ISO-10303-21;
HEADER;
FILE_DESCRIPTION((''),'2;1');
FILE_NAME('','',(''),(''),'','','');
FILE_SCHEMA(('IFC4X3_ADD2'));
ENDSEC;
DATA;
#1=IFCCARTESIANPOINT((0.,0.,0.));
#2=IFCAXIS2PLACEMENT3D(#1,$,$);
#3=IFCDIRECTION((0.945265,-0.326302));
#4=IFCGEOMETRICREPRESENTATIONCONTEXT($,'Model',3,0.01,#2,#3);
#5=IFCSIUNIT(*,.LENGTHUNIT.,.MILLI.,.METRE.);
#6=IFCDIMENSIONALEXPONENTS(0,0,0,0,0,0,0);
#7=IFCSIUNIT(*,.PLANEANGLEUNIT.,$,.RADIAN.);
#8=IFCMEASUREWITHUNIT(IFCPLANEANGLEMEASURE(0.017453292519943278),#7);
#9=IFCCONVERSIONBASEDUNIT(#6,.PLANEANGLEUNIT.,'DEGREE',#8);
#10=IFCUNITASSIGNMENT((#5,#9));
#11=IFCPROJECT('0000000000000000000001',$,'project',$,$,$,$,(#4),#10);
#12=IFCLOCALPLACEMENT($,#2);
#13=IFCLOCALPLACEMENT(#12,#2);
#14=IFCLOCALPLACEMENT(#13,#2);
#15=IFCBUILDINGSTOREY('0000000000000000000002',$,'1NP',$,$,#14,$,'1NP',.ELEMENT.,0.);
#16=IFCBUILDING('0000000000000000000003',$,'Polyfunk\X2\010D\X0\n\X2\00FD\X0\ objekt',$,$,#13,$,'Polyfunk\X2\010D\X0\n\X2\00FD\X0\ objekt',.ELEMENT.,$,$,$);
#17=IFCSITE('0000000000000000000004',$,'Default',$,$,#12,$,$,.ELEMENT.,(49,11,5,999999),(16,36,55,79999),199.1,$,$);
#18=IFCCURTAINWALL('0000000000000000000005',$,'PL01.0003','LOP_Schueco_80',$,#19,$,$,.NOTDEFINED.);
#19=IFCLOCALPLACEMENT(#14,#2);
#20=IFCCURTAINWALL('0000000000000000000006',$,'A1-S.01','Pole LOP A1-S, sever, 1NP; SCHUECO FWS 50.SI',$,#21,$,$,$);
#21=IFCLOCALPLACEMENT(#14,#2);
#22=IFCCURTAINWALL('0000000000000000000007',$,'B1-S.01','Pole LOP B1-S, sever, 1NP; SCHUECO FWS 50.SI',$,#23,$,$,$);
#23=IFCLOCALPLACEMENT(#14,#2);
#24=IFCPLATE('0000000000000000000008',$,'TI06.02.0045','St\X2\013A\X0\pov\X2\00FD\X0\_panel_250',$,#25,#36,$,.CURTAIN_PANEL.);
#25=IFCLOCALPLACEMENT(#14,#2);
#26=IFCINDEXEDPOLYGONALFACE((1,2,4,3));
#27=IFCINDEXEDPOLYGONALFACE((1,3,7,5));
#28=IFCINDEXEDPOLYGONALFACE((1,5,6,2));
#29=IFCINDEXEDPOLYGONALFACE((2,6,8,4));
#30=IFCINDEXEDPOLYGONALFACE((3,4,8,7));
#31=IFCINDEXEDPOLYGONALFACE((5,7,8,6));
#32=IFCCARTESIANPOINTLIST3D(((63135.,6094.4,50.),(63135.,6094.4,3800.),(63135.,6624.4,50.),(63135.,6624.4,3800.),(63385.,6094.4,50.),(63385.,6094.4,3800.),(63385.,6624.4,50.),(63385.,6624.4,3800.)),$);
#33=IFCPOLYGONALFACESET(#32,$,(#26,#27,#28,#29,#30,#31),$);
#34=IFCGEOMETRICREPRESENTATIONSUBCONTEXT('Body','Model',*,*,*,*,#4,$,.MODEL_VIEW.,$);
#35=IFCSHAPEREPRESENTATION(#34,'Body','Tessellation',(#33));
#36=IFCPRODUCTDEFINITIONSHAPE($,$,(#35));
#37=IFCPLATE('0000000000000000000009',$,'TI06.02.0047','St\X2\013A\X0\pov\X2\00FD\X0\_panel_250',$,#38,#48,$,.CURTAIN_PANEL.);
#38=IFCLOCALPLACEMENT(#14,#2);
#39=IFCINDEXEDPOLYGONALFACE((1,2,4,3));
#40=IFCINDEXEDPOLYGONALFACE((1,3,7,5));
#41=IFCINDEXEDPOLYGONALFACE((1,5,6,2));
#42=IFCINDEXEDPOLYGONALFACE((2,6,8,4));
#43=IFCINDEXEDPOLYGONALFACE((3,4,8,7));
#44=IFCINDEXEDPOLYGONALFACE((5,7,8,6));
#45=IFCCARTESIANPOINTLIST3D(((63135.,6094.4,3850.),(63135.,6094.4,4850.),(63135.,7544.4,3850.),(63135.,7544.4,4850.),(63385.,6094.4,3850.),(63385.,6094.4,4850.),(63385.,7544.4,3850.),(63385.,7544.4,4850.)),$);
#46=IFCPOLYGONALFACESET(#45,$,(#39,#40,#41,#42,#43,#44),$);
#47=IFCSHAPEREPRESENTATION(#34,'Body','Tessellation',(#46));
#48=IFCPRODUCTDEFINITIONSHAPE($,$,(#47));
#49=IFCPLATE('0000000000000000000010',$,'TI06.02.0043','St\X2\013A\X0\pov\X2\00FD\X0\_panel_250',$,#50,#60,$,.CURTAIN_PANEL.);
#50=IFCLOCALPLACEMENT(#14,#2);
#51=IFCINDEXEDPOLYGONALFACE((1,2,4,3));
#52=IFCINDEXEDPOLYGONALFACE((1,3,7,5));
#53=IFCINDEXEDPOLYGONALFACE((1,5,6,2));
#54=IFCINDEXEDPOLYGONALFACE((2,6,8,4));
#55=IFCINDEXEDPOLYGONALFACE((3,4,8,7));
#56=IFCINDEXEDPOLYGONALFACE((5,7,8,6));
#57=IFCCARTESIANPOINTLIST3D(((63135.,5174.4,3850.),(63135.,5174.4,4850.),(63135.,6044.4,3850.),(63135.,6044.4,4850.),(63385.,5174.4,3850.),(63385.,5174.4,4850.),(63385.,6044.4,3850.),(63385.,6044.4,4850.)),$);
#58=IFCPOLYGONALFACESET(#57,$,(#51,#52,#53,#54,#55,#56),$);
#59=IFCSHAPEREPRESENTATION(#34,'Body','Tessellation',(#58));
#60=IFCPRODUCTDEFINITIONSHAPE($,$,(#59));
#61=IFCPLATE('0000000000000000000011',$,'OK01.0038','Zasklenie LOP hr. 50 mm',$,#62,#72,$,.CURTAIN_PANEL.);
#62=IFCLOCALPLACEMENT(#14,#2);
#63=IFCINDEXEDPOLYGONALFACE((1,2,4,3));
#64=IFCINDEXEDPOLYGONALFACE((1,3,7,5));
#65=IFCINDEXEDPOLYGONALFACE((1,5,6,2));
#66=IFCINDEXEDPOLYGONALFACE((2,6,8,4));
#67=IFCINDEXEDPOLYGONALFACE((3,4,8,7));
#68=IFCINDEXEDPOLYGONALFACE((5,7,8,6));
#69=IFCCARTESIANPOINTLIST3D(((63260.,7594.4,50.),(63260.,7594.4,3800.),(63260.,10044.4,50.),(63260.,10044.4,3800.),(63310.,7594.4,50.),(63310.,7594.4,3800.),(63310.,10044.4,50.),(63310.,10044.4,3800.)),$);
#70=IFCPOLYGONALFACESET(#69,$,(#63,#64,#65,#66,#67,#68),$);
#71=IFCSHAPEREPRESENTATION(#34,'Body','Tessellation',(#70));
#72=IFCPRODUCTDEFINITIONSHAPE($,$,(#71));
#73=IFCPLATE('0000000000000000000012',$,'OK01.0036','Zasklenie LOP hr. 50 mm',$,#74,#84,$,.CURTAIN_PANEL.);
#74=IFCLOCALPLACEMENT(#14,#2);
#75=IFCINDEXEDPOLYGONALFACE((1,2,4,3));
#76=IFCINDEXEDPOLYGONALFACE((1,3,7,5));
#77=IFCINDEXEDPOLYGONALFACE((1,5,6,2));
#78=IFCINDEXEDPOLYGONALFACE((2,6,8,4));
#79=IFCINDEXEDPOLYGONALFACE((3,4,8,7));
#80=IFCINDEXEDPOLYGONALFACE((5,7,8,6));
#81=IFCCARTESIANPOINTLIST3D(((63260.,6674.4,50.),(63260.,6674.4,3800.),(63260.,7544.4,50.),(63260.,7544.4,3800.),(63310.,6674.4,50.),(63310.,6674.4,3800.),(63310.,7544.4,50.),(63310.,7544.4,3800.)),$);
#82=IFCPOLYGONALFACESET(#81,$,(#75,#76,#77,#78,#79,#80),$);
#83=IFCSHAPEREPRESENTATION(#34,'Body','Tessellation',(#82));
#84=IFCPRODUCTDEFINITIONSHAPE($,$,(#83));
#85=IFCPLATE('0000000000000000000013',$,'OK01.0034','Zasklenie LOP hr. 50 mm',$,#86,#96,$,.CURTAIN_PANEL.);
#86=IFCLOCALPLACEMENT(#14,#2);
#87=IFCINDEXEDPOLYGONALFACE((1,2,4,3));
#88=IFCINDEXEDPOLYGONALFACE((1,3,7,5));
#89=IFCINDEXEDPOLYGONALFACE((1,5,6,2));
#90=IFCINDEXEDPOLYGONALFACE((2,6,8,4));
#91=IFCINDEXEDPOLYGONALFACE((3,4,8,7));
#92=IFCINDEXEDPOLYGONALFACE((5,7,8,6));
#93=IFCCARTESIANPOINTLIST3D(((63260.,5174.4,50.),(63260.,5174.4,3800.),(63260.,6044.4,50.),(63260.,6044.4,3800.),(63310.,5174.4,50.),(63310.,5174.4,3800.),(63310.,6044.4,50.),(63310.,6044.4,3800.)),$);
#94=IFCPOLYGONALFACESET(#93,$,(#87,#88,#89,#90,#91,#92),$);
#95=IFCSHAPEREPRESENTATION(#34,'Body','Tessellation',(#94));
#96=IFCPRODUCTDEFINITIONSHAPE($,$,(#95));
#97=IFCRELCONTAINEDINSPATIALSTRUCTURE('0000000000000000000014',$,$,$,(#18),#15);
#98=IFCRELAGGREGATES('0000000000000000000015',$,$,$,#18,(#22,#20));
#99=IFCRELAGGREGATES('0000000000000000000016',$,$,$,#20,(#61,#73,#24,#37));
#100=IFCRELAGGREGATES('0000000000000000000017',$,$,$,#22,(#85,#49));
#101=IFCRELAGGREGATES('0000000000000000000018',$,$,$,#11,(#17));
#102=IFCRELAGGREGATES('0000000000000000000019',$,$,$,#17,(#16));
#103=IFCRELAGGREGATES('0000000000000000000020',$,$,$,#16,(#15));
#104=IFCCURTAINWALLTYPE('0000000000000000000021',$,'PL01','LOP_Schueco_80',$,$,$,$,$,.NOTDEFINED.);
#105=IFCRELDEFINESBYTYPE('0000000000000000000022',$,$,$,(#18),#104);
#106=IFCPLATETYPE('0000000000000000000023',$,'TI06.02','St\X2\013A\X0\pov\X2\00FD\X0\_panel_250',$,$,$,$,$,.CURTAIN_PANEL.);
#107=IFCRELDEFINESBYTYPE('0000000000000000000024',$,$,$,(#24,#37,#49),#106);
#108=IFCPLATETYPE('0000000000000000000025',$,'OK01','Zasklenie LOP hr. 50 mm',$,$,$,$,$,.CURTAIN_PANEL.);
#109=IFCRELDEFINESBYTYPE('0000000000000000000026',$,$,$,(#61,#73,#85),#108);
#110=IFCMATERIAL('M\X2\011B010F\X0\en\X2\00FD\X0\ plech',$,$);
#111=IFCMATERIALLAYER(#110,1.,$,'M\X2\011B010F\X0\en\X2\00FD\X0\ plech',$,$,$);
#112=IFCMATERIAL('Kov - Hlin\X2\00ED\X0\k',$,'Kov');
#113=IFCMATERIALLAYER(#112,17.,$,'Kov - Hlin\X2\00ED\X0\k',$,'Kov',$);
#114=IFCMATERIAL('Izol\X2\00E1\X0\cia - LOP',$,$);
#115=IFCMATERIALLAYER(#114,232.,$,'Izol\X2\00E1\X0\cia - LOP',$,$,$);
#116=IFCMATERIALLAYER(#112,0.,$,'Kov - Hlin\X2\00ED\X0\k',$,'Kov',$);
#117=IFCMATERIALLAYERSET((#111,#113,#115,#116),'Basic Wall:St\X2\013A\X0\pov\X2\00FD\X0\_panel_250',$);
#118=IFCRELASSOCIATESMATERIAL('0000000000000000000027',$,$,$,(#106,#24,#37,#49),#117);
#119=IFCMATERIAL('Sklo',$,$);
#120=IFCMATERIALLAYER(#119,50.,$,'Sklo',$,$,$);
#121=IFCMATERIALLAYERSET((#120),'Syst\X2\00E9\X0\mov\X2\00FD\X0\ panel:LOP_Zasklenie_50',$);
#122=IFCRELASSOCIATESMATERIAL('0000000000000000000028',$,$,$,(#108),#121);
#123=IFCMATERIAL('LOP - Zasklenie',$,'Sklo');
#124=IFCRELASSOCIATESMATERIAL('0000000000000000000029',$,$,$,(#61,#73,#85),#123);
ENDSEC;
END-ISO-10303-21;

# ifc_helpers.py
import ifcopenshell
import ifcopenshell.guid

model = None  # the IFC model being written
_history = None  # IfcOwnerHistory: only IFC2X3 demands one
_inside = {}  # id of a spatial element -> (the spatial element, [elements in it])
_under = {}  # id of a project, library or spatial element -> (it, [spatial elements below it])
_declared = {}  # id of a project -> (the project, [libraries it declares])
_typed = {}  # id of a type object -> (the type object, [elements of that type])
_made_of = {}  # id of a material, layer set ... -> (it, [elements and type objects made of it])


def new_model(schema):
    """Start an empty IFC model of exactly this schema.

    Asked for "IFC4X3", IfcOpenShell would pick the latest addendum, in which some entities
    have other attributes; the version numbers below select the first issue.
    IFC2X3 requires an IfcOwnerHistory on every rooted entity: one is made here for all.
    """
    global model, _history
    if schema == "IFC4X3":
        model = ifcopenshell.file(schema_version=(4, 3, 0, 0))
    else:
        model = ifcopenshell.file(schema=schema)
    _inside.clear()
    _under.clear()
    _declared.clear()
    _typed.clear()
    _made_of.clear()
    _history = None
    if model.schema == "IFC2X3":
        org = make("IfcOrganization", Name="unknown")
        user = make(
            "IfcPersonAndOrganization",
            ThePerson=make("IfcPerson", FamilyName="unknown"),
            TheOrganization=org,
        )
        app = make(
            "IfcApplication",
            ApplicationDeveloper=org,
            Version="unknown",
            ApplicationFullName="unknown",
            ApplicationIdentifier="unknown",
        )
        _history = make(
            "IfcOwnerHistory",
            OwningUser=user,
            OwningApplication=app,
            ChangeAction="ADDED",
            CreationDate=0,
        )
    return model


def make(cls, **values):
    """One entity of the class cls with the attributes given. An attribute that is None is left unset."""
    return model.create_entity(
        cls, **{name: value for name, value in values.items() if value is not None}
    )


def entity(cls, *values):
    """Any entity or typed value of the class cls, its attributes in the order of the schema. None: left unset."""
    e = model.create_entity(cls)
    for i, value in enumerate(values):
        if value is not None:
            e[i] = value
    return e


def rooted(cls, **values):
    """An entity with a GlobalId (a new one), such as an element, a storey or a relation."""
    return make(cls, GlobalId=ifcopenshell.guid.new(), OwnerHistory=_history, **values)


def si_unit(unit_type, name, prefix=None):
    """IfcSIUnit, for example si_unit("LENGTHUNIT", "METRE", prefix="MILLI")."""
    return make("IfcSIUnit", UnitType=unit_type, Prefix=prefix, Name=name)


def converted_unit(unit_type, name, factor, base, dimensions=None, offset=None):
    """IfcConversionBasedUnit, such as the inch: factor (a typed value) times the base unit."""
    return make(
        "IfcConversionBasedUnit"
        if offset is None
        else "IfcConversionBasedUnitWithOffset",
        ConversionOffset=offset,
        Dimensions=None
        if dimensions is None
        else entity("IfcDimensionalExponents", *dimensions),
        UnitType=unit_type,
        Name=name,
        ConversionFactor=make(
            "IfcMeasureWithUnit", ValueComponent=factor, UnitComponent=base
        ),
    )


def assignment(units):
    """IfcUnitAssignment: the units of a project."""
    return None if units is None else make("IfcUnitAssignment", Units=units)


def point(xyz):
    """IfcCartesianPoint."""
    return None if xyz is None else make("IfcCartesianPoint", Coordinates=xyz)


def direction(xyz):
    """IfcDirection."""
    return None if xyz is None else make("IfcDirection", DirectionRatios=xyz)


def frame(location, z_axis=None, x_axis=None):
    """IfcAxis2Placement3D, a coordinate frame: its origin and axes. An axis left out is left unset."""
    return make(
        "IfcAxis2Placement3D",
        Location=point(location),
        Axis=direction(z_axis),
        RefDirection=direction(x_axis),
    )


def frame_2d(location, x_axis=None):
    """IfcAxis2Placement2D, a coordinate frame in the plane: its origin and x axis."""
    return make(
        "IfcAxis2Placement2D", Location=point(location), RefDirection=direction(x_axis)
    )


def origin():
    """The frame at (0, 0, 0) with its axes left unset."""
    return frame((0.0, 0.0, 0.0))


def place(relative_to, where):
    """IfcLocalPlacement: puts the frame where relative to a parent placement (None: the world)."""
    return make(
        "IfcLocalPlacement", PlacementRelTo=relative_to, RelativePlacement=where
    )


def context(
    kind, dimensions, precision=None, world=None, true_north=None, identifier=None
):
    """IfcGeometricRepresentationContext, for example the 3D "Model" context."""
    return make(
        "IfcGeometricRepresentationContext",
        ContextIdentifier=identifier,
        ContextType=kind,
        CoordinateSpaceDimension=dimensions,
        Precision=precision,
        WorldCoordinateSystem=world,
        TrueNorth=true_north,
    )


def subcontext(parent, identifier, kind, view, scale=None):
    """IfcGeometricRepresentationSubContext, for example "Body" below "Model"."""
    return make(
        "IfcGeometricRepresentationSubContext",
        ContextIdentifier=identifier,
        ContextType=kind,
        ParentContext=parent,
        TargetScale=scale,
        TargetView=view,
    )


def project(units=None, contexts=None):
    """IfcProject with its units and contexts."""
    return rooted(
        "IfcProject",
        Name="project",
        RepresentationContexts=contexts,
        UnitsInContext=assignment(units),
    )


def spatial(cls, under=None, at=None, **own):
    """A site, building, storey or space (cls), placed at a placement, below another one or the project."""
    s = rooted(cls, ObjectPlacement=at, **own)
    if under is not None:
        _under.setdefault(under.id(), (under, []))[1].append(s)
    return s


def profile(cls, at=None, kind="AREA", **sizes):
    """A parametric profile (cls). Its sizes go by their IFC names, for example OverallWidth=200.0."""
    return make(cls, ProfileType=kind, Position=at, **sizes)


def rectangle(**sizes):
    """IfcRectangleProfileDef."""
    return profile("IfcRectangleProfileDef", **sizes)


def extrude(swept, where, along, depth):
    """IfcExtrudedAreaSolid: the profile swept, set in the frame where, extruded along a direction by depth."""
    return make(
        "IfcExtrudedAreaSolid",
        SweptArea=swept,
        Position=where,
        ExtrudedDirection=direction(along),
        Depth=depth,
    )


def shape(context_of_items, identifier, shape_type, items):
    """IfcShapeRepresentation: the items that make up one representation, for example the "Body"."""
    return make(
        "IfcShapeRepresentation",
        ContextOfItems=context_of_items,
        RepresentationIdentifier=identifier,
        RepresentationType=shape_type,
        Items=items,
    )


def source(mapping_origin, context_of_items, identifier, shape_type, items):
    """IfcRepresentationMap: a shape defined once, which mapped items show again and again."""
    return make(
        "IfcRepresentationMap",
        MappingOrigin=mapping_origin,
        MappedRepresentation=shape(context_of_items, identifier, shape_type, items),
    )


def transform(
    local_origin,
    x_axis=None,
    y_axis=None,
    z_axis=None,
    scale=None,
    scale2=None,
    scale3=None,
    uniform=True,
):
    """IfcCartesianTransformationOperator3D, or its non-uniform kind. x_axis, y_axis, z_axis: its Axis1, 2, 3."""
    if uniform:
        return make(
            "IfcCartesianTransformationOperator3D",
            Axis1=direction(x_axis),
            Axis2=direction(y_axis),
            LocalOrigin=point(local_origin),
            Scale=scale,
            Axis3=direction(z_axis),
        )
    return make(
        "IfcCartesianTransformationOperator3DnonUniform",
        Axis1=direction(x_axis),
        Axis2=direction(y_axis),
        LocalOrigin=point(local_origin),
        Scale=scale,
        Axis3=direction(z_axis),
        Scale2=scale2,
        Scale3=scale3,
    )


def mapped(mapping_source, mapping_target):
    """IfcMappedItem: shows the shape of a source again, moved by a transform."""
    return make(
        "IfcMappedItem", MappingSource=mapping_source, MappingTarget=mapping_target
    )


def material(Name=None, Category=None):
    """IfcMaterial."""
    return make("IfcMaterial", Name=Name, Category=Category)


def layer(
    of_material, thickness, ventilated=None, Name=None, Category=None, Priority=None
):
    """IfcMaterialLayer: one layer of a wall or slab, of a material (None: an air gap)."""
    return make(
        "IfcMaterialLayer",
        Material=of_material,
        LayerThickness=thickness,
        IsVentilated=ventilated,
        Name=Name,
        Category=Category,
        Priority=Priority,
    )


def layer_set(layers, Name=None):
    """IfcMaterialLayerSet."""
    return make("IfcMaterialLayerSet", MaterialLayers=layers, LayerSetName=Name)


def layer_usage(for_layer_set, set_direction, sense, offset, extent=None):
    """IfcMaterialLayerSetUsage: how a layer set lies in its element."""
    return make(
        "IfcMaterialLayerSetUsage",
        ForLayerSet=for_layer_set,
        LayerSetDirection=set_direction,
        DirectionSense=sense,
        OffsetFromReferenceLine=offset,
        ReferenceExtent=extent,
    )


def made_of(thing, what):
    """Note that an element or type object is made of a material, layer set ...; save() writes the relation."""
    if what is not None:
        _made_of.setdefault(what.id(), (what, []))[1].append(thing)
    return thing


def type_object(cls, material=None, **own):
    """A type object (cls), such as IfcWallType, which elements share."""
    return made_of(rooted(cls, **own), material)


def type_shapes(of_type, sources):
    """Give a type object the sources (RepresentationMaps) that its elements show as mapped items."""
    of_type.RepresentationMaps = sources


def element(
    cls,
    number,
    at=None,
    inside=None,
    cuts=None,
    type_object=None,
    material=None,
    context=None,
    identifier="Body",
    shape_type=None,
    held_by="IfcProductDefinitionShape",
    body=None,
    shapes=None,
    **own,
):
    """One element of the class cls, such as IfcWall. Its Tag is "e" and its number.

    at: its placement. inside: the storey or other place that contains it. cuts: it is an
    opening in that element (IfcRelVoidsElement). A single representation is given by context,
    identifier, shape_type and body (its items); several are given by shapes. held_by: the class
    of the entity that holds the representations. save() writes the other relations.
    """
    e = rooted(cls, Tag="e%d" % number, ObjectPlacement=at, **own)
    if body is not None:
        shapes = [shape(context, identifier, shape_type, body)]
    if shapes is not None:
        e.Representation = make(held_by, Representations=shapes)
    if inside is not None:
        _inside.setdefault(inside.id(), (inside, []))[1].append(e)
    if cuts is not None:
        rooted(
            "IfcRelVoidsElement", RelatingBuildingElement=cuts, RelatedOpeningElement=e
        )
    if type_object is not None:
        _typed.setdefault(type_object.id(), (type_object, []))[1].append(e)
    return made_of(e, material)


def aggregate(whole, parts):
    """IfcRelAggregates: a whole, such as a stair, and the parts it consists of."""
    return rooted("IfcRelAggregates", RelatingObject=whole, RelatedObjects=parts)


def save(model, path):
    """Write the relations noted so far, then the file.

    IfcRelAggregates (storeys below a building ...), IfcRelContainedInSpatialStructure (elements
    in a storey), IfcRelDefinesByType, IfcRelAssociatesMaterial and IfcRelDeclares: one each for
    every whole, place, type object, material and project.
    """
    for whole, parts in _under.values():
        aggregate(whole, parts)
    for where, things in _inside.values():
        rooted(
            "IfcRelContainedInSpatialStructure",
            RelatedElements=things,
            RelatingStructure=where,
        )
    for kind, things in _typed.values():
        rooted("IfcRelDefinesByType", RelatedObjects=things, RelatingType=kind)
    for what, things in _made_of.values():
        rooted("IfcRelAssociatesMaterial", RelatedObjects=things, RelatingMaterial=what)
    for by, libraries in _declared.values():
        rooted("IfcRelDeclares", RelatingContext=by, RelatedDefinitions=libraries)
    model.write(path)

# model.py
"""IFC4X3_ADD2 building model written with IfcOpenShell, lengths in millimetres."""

from ifc_helpers import new_model, entity, si_unit, converted_unit, direction, frame, frame_2d, origin, place, context, subcontext, project, spatial, rectangle, extrude, source, transform, mapped, material, layer, layer_set, layer_usage, type_object, type_shapes, element, aggregate, save


model = new_model("IFC4X3_ADD2")

# Units and contexts
model_context = context("Model", 3, precision=0.01, world=origin(), true_north=direction((0.945265, -0.326302)))
body_context = subcontext(model_context, "Body", "Model", "MODEL_VIEW")
ifc_project = project(units=[si_unit("LENGTHUNIT", "METRE", prefix="MILLI"), converted_unit("PLANEANGLEUNIT", "DEGREE", entity("IfcPlaneAngleMeasure", 0.017453292519943278), si_unit("PLANEANGLEUNIT", "RADIAN"), dimensions=[0, 0, 0, 0, 0, 0, 0])], contexts=[model_context])

# Site, building, storey
site_placement = place(None, origin())
site = spatial("IfcSite", under=ifc_project, at=site_placement, Name="Default", CompositionType="ELEMENT", RefLatitude=(49, 11, 5, 999999), RefLongitude=(16, 36, 55, 79999), RefElevation=199.1)
building_placement = place(site_placement, origin())
building = spatial("IfcBuilding", under=site, at=building_placement, Name="Polyfunkčný objekt", LongName="Polyfunkčný objekt", CompositionType="ELEMENT")
storey_placement = place(building_placement, origin())
storey = spatial("IfcBuildingStorey", under=building, at=storey_placement, Name="1NP", LongName="1NP", CompositionType="ELEMENT", Elevation=0.0)

# Curtain walls, plates
curtain_wall_type = type_object("IfcCurtainWallType", Name="PL01", Description="LOP_Schueco_80", PredefinedType="NOTDEFINED")
curtain_wall_1_placement = place(storey_placement, origin())
curtain_wall_1 = element("IfcCurtainWall", 1, at=curtain_wall_1_placement, inside=storey, type_object=curtain_wall_type, Name="PL01.0003", Description="LOP_Schueco_80", PredefinedType="NOTDEFINED")
curtain_wall_2 = element("IfcCurtainWall", 2, Name="A1-S.01", Description="Pole LOP A1-S, sever, 1NP; SCHUECO FWS 50.SI")
curtain_wall_3 = element("IfcCurtainWall", 3, Name="B1-S.01", Description="Pole LOP B1-S, sever, 1NP; SCHUECO FWS 50.SI")
aggregate(curtain_wall_1, [curtain_wall_3, curtain_wall_2])
ifc_material_1 = material(Name="Měďený plech")
ifc_layer_1 = layer(ifc_material_1, 1.0, Name="Měďený plech")
ifc_material_2 = material(Name="Kov - Hliník", Category="Kov")
ifc_layer_2 = layer(ifc_material_2, 17.0, Name="Kov - Hliník", Category="Kov")
ifc_material_3 = material(Name="Izolácia - LOP")
ifc_layer_3 = layer(ifc_material_3, 232.0, Name="Izolácia - LOP")
ifc_layer_4 = layer(ifc_material_2, 0.0, Name="Kov - Hliník", Category="Kov")
ifc_layer_set_1 = layer_set([ifc_layer_1, ifc_layer_2, ifc_layer_3, ifc_layer_4], Name="Basic Wall:Stĺpový_panel_250")
ifc_layer_usage_1 = layer_usage(ifc_layer_set_1, "AXIS2", "NEGATIVE", 125.0)
plate_type_1 = type_object("IfcPlateType", Name="TI06.02", Description="Stĺpový_panel_250", PredefinedType="CURTAIN_PANEL", material=ifc_layer_set_1)
plate_1_placement = place(storey_placement, frame((63260.0, 6624.4, 50.0), z_axis=(0.0, 0.0, 1.0), x_axis=(0.0, -1.0, 0.0)))
plate_1 = element("IfcPlate", 4, at=plate_1_placement, type_object=plate_type_1, material=ifc_layer_usage_1, Name="TI06.02.0045", Description="Stĺpový_panel_250", PredefinedType="CURTAIN_PANEL", context=body_context, shape_type="SweptSolid", body=[
    extrude(rectangle(XDim=250.0, YDim=530.0, at=frame_2d((0.0, 0.0), x_axis=(1.0, 0.0))), frame((265.0, 0.0, 0.0), z_axis=(0.0, 0.0, 1.0), x_axis=(0.0, 1.0, 0.0)), (0.0, 0.0, 1.0), 3750.0),
])
ifc_layer_usage_2 = layer_usage(ifc_layer_set_1, "AXIS2", "NEGATIVE", 125.0)
plate_2_placement = place(storey_placement, frame((63260.0, 7544.4, 3850.0), z_axis=(0.0, 0.0, 1.0), x_axis=(0.0, -1.0, 0.0)))
plate_2 = element("IfcPlate", 5, at=plate_2_placement, type_object=plate_type_1, material=ifc_layer_usage_2, Name="TI06.02.0047", Description="Stĺpový_panel_250", PredefinedType="CURTAIN_PANEL", context=body_context, shape_type="SweptSolid", body=[
    extrude(rectangle(XDim=250.0, YDim=1450.0, at=frame_2d((0.0, 0.0), x_axis=(1.0, 0.0))), frame((725.0, 0.0, 0.0), z_axis=(0.0, 0.0, 1.0), x_axis=(0.0, 1.0, 0.0)), (0.0, 0.0, 1.0), 1000.0),
])
ifc_layer_usage_3 = layer_usage(ifc_layer_set_1, "AXIS2", "NEGATIVE", 125.0)
plate_3_placement = place(storey_placement, frame((63260.0, 6044.4, 3850.0), z_axis=(0.0, 0.0, 1.0), x_axis=(0.0, -1.0, 0.0)))
plate_3 = element("IfcPlate", 6, at=plate_3_placement, type_object=plate_type_1, material=ifc_layer_usage_3, Name="TI06.02.0043", Description="Stĺpový_panel_250", PredefinedType="CURTAIN_PANEL", context=body_context, shape_type="SweptSolid", body=[
    extrude(rectangle(XDim=250.0, YDim=870.0, at=frame_2d((0.0, 0.0), x_axis=(1.0, 0.0))), frame((435.0, 0.0, 0.0), z_axis=(0.0, 0.0, 1.0), x_axis=(0.0, 1.0, 0.0)), (0.0, 0.0, 1.0), 1000.0),
])
ifc_material_4 = material(Name="LOP - Zasklenie", Category="Sklo")
ifc_material_5 = material(Name="Sklo")
ifc_layer_5 = layer(ifc_material_5, 50.0, Name="Sklo")
ifc_layer_set_2 = layer_set([ifc_layer_5], Name="Systémový panel:LOP_Zasklenie_50")
plate_type_2 = type_object("IfcPlateType", Name="OK01", Description="Zasklenie LOP hr. 50 mm", PredefinedType="CURTAIN_PANEL", material=ifc_layer_set_2)
shared_shape_1 = source(origin(), body_context, "Body", "SweptSolid", [
    extrude(rectangle(XDim=3750.0, YDim=2450.0, at=frame_2d((-141.7, 0.0), x_axis=(1.0, 0.0))), frame((0.0, 0.0, 2016.7), z_axis=(0.0, 1.0, 0.0), x_axis=(0.0, 0.0, 1.0)), (0.0, 0.0, 1.0), 50.0),
])
plate_4_placement = place(curtain_wall_1_placement, frame((63260.0, 8819.4, 50.0), z_axis=(0.0, 0.0, 1.0), x_axis=(0.0, -1.0, 0.0)))
plate_4 = element("IfcPlate", 7, at=plate_4_placement, type_object=plate_type_2, material=ifc_material_4, Name="OK01.0038", Description="Zasklenie LOP hr. 50 mm", PredefinedType="CURTAIN_PANEL", context=body_context, shape_type="MappedRepresentation", body=[
    mapped(shared_shape_1, transform((0.0, 0.0, 0.0), scale=1.0)),
])
shared_shape_2 = source(origin(), body_context, "Body", "SweptSolid", [
    extrude(rectangle(XDim=3750.0, YDim=870.0, at=frame_2d((-141.7, 0.0), x_axis=(1.0, 0.0))), frame((0.0, 0.0, 2016.7), z_axis=(0.0, 1.0, 0.0), x_axis=(0.0, 0.0, 1.0)), (0.0, 0.0, 1.0), 50.0),
])
type_shapes(plate_type_2, [shared_shape_1, shared_shape_2])
plate_5_placement = place(curtain_wall_1_placement, frame((63260.0, 7109.4, 50.0), z_axis=(0.0, 0.0, 1.0), x_axis=(0.0, -1.0, 0.0)))
plate_5 = element("IfcPlate", 8, at=plate_5_placement, type_object=plate_type_2, material=ifc_material_4, Name="OK01.0036", Description="Zasklenie LOP hr. 50 mm", PredefinedType="CURTAIN_PANEL", context=body_context, shape_type="MappedRepresentation", body=[
    mapped(shared_shape_2, transform((0.0, 0.0, 0.0), scale=1.0)),
])
aggregate(curtain_wall_2, [plate_4, plate_5, plate_1, plate_2])
plate_6_placement = place(curtain_wall_1_placement, frame((63260.0, 5609.4, 50.0), z_axis=(0.0, 0.0, 1.0), x_axis=(0.0, -1.0, 0.0)))
plate_6 = element("IfcPlate", 9, at=plate_6_placement, type_object=plate_type_2, material=ifc_material_4, Name="OK01.0034", Description="Zasklenie LOP hr. 50 mm", PredefinedType="CURTAIN_PANEL", context=body_context, shape_type="MappedRepresentation", body=[
    mapped(shared_shape_2, transform((0.0, 0.0, 0.0), scale=1.0)),
])
aggregate(curtain_wall_3, [plate_6, plate_3])

save(model, "model.ifc")
